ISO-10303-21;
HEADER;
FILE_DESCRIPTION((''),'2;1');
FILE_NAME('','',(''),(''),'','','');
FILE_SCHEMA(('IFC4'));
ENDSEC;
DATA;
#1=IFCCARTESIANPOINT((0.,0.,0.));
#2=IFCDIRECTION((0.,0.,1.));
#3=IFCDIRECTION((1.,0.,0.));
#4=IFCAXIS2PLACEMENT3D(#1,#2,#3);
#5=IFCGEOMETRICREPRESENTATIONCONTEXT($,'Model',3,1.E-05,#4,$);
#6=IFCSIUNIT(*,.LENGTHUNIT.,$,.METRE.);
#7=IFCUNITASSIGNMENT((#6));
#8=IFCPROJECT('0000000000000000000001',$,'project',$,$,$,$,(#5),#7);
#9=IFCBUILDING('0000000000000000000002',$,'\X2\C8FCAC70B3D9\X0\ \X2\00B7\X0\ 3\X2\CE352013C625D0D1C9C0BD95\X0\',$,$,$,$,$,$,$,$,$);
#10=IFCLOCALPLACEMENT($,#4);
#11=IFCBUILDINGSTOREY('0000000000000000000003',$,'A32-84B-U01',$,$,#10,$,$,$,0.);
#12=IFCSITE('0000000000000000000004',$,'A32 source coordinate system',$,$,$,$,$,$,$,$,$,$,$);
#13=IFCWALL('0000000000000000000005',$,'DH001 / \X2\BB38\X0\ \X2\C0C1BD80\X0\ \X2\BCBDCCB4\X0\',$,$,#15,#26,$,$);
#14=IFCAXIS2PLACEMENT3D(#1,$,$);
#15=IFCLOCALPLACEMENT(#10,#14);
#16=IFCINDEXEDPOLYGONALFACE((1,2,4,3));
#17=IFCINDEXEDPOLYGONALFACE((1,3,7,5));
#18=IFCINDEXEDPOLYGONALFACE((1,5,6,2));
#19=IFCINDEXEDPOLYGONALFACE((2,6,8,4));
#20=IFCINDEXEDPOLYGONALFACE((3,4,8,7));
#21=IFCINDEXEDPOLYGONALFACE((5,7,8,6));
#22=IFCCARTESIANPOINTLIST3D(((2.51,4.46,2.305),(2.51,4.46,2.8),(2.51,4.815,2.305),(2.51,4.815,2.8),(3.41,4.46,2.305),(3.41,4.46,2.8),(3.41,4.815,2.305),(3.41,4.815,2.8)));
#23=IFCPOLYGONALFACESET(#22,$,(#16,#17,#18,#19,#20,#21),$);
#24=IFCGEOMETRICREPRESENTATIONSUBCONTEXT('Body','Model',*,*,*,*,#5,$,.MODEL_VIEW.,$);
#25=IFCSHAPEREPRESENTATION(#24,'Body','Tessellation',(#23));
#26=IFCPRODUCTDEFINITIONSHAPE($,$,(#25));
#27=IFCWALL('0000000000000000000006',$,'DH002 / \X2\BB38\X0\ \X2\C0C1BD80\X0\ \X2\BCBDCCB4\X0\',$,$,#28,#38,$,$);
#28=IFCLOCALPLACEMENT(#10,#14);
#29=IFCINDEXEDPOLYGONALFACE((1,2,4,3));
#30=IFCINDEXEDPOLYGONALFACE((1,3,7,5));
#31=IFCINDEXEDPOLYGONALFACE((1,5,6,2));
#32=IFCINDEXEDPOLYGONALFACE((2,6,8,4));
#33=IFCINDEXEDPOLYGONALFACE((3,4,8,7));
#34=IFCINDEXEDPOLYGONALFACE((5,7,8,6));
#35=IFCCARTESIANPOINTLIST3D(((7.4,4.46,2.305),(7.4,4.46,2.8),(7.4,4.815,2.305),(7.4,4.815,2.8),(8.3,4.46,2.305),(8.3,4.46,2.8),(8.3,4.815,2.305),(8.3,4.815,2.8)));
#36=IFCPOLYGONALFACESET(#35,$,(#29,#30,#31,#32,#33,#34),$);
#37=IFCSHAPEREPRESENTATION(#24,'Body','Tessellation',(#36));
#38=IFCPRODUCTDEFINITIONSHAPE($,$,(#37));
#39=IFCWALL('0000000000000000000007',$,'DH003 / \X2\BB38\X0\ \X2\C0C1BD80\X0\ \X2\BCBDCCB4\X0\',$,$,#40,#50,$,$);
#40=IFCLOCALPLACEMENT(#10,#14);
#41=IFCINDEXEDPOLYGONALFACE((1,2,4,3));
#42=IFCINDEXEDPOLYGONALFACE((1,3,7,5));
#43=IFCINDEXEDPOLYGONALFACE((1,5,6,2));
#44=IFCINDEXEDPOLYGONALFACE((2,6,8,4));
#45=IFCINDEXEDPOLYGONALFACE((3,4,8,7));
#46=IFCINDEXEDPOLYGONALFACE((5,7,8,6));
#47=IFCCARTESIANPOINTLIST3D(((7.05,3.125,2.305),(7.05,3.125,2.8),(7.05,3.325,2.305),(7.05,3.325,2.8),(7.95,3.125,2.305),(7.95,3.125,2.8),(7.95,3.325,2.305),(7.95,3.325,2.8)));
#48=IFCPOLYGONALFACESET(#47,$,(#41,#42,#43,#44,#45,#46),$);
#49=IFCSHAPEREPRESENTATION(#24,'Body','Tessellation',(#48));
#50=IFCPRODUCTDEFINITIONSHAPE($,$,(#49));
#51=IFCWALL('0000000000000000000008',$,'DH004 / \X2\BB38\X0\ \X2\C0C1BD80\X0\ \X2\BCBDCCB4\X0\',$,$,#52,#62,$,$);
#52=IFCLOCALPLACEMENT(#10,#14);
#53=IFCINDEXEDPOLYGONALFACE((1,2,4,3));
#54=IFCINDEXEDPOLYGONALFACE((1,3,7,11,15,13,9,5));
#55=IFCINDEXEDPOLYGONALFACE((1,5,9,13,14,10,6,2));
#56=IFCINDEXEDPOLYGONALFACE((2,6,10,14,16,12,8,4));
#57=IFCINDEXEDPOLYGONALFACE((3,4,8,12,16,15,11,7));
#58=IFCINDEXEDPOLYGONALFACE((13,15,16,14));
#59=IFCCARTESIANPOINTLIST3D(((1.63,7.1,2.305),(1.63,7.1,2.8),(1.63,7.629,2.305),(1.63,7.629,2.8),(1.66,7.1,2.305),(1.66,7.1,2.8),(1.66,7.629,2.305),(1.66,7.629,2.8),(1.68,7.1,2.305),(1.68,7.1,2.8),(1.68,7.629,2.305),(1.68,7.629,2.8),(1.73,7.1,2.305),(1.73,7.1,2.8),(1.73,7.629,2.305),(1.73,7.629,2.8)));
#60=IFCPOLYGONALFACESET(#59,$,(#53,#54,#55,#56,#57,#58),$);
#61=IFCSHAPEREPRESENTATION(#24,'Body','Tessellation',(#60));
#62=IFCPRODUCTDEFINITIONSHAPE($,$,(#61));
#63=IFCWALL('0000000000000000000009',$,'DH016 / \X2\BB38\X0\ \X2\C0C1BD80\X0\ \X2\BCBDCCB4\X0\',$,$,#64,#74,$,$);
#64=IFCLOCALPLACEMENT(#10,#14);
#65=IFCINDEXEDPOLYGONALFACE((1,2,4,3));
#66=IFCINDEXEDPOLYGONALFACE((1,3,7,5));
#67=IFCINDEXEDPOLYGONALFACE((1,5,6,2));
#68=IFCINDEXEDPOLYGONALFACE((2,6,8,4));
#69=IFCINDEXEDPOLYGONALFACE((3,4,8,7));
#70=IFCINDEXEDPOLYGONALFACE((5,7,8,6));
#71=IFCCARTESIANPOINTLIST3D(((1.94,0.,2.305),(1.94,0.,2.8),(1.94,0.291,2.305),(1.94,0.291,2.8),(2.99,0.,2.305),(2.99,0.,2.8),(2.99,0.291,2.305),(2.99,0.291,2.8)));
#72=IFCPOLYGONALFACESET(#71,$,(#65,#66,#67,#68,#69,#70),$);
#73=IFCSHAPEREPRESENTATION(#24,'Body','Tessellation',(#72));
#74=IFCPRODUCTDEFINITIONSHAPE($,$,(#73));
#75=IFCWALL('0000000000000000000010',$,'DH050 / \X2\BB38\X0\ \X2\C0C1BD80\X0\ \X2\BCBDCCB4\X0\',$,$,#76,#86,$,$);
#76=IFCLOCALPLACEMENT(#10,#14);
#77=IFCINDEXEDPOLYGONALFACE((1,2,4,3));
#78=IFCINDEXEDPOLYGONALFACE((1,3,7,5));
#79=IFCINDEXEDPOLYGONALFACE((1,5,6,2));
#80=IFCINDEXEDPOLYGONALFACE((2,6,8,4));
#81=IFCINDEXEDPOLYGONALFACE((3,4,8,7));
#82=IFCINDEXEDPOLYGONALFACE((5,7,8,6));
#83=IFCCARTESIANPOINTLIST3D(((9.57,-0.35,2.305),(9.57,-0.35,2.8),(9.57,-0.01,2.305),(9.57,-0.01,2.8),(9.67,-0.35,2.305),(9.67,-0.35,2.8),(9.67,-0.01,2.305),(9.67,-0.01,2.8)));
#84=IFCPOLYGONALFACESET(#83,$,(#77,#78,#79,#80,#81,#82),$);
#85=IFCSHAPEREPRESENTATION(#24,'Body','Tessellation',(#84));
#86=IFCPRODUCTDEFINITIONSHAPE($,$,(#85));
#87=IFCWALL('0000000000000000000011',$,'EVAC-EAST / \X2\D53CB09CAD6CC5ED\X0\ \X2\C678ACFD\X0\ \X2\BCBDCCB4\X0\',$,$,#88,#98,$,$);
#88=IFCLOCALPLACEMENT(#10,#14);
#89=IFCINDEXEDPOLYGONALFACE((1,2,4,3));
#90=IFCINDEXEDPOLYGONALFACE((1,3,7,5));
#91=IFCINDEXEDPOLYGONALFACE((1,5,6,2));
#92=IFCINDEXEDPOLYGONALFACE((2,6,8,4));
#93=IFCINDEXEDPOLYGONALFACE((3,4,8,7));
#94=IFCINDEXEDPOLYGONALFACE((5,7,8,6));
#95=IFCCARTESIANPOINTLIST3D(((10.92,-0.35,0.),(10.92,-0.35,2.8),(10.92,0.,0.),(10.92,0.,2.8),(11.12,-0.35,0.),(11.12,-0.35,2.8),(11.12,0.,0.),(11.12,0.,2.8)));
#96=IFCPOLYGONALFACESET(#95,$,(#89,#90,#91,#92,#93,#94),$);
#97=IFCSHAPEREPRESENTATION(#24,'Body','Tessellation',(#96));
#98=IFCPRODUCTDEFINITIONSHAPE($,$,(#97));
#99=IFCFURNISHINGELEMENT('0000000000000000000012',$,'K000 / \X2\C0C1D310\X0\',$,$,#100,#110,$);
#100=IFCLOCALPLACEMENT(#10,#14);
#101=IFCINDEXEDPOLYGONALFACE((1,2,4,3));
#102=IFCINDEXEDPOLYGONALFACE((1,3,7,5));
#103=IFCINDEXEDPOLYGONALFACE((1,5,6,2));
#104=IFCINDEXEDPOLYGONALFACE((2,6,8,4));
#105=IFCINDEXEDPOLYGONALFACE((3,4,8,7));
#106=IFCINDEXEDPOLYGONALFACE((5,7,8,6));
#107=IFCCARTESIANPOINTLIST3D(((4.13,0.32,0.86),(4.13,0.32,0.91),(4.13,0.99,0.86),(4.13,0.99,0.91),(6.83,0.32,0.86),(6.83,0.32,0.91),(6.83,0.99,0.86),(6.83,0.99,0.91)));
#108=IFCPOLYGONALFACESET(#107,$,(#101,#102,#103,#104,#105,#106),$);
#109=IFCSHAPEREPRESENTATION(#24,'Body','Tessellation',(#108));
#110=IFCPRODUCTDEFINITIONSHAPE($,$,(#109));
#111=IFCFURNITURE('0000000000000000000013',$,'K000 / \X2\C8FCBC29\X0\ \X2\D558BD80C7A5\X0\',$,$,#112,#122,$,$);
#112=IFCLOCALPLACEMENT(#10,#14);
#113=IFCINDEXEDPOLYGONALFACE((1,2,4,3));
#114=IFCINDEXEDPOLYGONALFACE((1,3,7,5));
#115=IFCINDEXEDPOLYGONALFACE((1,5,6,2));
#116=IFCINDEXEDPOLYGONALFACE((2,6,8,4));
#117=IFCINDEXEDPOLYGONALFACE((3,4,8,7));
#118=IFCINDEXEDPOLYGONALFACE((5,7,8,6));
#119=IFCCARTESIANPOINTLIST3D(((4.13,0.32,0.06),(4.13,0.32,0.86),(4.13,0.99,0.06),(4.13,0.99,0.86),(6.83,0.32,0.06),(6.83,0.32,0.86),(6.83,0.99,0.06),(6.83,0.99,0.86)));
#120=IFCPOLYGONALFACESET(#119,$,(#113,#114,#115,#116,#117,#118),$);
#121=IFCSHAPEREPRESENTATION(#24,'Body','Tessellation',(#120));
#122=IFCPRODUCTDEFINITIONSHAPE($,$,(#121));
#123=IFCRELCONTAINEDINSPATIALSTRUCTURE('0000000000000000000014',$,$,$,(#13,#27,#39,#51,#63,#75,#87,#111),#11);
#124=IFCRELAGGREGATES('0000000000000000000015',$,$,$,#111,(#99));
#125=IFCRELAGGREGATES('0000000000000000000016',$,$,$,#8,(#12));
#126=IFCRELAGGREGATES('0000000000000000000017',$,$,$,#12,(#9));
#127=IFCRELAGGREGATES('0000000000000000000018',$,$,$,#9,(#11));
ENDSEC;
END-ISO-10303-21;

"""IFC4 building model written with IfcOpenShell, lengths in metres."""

from ifc_helpers import new_model, si_unit, frame, origin, origin_with_axes, place, context, subcontext, project, spatial, polyline, outline, extrude, element, aggregate, save


model = new_model("IFC4")

# Units and contexts
model_context = context("Model", 3, precision=1e-05, world=origin_with_axes())
body_context = subcontext(model_context, "Body", "Model", "MODEL_VIEW")
ifc_project = project(units=[si_unit("LENGTHUNIT", "METRE")], contexts=[model_context])

# Site, building, storey
site = spatial("IfcSite", under=ifc_project, Name="A32 source coordinate system")
building = spatial("IfcBuilding", under=site, Name="주거동 · 3층–옥탑지붕")
storey_placement = place(None, origin_with_axes())
storey = spatial("IfcBuildingStorey", under=building, at=storey_placement, Name="A32-84B-U01", Elevation=0.0)

# Walls
wall_1_placement = place(storey_placement, origin_with_axes())
element("IfcWall", 1, at=wall_1_placement, inside=storey, Name="DH001 / 문 상부 벽체", context=body_context, shape_type="SweptSolid", body=[
    extrude(outline(polyline([(3.41, 4.815), (3.41, 4.46), (2.51, 4.46), (2.51, 4.815), (3.41, 4.815)])), frame((0.0, 0.0, 2.305)), (0.0, 0.0, 1.0), 0.495),
])
wall_2_placement = place(storey_placement, origin_with_axes())
element("IfcWall", 2, at=wall_2_placement, inside=storey, Name="DH002 / 문 상부 벽체", context=body_context, shape_type="SweptSolid", body=[
    extrude(outline(polyline([(8.3, 4.815), (8.3, 4.46), (7.4, 4.46), (7.4, 4.815), (8.3, 4.815)])), frame((0.0, 0.0, 2.305)), (0.0, 0.0, 1.0), 0.495),
])
wall_3_placement = place(storey_placement, origin_with_axes())
element("IfcWall", 3, at=wall_3_placement, inside=storey, Name="DH003 / 문 상부 벽체", context=body_context, shape_type="SweptSolid", body=[
    extrude(outline(polyline([(7.95, 3.325), (7.95, 3.125), (7.05, 3.125), (7.05, 3.325), (7.95, 3.325)])), frame((0.0, 0.0, 2.305)), (0.0, 0.0, 1.0), 0.495),
])
wall_4_placement = place(storey_placement, origin_with_axes())
element("IfcWall", 4, at=wall_4_placement, inside=storey, Name="DH004 / 문 상부 벽체", context=body_context, shape_type="SweptSolid", body=[
    extrude(outline(polyline([(1.66, 7.1), (1.63, 7.1), (1.63, 7.629), (1.66, 7.629), (1.68, 7.629), (1.73, 7.629), (1.73, 7.1), (1.68, 7.1), (1.66, 7.1)])), frame((0.0, 0.0, 2.305)), (0.0, 0.0, 1.0), 0.495),
])
wall_5_placement = place(storey_placement, origin_with_axes())
element("IfcWall", 5, at=wall_5_placement, inside=storey, Name="DH016 / 문 상부 벽체", context=body_context, shape_type="SweptSolid", body=[
    extrude(outline(polyline([(2.99, 0.291), (2.99, 0.0), (1.94, 0.0), (1.94, 0.291), (2.99, 0.291)])), frame((0.0, 0.0, 2.305)), (0.0, 0.0, 1.0), 0.495),
])
wall_6_placement = place(storey_placement, origin_with_axes())
element("IfcWall", 6, at=wall_6_placement, inside=storey, Name="DH050 / 문 상부 벽체", context=body_context, shape_type="SweptSolid", body=[
    extrude(outline(polyline([(9.67, -0.01), (9.67, -0.35), (9.57, -0.35), (9.57, -0.01), (9.67, -0.01)])), frame((0.0, 0.0, 2.305)), (0.0, 0.0, 1.0), 0.495),
])
wall_7_placement = place(storey_placement, origin_with_axes())
element("IfcWall", 7, at=wall_7_placement, inside=storey, Name="EVAC-EAST / 피난구역 외곽 벽체", context=body_context, shape_type="SweptSolid", body=[
    extrude(outline(polyline([(10.92, 0.0), (11.12, 0.0), (11.12, -0.35), (10.92, -0.35), (10.92, 0.0)])), origin(), (0.0, 0.0, 1.0), 2.8),
])

# Furnishing element
furniture_placement = place(storey_placement, origin_with_axes())
furnishing_placement = place(furniture_placement, origin_with_axes())
furnishing = element("IfcFurnishingElement", 8, at=furnishing_placement, Name="K000 / 상판", context=body_context, shape_type="SweptSolid", body=[
    extrude(outline(polyline([(4.13, 0.32), (4.13, 0.99), (6.83, 0.99), (6.83, 0.32), (4.13, 0.32)])), frame((0.0, 0.0, 0.86)), (0.0, 0.0, 1.0), 0.05),
])

# Furniture
furniture = element("IfcFurniture", 9, at=furniture_placement, inside=storey, Name="K000 / 주방 하부장", context=body_context, shape_type="SweptSolid", body=[
    extrude(outline(polyline([(6.83, 0.32), (4.13, 0.32), (4.13, 0.99), (6.83, 0.99), (6.83, 0.32)])), frame((0.0, 0.0, 0.06)), (0.0, 0.0, 1.0), 0.8),
])
aggregate(furniture, [furnishing])

save(model, "model.ifc")
